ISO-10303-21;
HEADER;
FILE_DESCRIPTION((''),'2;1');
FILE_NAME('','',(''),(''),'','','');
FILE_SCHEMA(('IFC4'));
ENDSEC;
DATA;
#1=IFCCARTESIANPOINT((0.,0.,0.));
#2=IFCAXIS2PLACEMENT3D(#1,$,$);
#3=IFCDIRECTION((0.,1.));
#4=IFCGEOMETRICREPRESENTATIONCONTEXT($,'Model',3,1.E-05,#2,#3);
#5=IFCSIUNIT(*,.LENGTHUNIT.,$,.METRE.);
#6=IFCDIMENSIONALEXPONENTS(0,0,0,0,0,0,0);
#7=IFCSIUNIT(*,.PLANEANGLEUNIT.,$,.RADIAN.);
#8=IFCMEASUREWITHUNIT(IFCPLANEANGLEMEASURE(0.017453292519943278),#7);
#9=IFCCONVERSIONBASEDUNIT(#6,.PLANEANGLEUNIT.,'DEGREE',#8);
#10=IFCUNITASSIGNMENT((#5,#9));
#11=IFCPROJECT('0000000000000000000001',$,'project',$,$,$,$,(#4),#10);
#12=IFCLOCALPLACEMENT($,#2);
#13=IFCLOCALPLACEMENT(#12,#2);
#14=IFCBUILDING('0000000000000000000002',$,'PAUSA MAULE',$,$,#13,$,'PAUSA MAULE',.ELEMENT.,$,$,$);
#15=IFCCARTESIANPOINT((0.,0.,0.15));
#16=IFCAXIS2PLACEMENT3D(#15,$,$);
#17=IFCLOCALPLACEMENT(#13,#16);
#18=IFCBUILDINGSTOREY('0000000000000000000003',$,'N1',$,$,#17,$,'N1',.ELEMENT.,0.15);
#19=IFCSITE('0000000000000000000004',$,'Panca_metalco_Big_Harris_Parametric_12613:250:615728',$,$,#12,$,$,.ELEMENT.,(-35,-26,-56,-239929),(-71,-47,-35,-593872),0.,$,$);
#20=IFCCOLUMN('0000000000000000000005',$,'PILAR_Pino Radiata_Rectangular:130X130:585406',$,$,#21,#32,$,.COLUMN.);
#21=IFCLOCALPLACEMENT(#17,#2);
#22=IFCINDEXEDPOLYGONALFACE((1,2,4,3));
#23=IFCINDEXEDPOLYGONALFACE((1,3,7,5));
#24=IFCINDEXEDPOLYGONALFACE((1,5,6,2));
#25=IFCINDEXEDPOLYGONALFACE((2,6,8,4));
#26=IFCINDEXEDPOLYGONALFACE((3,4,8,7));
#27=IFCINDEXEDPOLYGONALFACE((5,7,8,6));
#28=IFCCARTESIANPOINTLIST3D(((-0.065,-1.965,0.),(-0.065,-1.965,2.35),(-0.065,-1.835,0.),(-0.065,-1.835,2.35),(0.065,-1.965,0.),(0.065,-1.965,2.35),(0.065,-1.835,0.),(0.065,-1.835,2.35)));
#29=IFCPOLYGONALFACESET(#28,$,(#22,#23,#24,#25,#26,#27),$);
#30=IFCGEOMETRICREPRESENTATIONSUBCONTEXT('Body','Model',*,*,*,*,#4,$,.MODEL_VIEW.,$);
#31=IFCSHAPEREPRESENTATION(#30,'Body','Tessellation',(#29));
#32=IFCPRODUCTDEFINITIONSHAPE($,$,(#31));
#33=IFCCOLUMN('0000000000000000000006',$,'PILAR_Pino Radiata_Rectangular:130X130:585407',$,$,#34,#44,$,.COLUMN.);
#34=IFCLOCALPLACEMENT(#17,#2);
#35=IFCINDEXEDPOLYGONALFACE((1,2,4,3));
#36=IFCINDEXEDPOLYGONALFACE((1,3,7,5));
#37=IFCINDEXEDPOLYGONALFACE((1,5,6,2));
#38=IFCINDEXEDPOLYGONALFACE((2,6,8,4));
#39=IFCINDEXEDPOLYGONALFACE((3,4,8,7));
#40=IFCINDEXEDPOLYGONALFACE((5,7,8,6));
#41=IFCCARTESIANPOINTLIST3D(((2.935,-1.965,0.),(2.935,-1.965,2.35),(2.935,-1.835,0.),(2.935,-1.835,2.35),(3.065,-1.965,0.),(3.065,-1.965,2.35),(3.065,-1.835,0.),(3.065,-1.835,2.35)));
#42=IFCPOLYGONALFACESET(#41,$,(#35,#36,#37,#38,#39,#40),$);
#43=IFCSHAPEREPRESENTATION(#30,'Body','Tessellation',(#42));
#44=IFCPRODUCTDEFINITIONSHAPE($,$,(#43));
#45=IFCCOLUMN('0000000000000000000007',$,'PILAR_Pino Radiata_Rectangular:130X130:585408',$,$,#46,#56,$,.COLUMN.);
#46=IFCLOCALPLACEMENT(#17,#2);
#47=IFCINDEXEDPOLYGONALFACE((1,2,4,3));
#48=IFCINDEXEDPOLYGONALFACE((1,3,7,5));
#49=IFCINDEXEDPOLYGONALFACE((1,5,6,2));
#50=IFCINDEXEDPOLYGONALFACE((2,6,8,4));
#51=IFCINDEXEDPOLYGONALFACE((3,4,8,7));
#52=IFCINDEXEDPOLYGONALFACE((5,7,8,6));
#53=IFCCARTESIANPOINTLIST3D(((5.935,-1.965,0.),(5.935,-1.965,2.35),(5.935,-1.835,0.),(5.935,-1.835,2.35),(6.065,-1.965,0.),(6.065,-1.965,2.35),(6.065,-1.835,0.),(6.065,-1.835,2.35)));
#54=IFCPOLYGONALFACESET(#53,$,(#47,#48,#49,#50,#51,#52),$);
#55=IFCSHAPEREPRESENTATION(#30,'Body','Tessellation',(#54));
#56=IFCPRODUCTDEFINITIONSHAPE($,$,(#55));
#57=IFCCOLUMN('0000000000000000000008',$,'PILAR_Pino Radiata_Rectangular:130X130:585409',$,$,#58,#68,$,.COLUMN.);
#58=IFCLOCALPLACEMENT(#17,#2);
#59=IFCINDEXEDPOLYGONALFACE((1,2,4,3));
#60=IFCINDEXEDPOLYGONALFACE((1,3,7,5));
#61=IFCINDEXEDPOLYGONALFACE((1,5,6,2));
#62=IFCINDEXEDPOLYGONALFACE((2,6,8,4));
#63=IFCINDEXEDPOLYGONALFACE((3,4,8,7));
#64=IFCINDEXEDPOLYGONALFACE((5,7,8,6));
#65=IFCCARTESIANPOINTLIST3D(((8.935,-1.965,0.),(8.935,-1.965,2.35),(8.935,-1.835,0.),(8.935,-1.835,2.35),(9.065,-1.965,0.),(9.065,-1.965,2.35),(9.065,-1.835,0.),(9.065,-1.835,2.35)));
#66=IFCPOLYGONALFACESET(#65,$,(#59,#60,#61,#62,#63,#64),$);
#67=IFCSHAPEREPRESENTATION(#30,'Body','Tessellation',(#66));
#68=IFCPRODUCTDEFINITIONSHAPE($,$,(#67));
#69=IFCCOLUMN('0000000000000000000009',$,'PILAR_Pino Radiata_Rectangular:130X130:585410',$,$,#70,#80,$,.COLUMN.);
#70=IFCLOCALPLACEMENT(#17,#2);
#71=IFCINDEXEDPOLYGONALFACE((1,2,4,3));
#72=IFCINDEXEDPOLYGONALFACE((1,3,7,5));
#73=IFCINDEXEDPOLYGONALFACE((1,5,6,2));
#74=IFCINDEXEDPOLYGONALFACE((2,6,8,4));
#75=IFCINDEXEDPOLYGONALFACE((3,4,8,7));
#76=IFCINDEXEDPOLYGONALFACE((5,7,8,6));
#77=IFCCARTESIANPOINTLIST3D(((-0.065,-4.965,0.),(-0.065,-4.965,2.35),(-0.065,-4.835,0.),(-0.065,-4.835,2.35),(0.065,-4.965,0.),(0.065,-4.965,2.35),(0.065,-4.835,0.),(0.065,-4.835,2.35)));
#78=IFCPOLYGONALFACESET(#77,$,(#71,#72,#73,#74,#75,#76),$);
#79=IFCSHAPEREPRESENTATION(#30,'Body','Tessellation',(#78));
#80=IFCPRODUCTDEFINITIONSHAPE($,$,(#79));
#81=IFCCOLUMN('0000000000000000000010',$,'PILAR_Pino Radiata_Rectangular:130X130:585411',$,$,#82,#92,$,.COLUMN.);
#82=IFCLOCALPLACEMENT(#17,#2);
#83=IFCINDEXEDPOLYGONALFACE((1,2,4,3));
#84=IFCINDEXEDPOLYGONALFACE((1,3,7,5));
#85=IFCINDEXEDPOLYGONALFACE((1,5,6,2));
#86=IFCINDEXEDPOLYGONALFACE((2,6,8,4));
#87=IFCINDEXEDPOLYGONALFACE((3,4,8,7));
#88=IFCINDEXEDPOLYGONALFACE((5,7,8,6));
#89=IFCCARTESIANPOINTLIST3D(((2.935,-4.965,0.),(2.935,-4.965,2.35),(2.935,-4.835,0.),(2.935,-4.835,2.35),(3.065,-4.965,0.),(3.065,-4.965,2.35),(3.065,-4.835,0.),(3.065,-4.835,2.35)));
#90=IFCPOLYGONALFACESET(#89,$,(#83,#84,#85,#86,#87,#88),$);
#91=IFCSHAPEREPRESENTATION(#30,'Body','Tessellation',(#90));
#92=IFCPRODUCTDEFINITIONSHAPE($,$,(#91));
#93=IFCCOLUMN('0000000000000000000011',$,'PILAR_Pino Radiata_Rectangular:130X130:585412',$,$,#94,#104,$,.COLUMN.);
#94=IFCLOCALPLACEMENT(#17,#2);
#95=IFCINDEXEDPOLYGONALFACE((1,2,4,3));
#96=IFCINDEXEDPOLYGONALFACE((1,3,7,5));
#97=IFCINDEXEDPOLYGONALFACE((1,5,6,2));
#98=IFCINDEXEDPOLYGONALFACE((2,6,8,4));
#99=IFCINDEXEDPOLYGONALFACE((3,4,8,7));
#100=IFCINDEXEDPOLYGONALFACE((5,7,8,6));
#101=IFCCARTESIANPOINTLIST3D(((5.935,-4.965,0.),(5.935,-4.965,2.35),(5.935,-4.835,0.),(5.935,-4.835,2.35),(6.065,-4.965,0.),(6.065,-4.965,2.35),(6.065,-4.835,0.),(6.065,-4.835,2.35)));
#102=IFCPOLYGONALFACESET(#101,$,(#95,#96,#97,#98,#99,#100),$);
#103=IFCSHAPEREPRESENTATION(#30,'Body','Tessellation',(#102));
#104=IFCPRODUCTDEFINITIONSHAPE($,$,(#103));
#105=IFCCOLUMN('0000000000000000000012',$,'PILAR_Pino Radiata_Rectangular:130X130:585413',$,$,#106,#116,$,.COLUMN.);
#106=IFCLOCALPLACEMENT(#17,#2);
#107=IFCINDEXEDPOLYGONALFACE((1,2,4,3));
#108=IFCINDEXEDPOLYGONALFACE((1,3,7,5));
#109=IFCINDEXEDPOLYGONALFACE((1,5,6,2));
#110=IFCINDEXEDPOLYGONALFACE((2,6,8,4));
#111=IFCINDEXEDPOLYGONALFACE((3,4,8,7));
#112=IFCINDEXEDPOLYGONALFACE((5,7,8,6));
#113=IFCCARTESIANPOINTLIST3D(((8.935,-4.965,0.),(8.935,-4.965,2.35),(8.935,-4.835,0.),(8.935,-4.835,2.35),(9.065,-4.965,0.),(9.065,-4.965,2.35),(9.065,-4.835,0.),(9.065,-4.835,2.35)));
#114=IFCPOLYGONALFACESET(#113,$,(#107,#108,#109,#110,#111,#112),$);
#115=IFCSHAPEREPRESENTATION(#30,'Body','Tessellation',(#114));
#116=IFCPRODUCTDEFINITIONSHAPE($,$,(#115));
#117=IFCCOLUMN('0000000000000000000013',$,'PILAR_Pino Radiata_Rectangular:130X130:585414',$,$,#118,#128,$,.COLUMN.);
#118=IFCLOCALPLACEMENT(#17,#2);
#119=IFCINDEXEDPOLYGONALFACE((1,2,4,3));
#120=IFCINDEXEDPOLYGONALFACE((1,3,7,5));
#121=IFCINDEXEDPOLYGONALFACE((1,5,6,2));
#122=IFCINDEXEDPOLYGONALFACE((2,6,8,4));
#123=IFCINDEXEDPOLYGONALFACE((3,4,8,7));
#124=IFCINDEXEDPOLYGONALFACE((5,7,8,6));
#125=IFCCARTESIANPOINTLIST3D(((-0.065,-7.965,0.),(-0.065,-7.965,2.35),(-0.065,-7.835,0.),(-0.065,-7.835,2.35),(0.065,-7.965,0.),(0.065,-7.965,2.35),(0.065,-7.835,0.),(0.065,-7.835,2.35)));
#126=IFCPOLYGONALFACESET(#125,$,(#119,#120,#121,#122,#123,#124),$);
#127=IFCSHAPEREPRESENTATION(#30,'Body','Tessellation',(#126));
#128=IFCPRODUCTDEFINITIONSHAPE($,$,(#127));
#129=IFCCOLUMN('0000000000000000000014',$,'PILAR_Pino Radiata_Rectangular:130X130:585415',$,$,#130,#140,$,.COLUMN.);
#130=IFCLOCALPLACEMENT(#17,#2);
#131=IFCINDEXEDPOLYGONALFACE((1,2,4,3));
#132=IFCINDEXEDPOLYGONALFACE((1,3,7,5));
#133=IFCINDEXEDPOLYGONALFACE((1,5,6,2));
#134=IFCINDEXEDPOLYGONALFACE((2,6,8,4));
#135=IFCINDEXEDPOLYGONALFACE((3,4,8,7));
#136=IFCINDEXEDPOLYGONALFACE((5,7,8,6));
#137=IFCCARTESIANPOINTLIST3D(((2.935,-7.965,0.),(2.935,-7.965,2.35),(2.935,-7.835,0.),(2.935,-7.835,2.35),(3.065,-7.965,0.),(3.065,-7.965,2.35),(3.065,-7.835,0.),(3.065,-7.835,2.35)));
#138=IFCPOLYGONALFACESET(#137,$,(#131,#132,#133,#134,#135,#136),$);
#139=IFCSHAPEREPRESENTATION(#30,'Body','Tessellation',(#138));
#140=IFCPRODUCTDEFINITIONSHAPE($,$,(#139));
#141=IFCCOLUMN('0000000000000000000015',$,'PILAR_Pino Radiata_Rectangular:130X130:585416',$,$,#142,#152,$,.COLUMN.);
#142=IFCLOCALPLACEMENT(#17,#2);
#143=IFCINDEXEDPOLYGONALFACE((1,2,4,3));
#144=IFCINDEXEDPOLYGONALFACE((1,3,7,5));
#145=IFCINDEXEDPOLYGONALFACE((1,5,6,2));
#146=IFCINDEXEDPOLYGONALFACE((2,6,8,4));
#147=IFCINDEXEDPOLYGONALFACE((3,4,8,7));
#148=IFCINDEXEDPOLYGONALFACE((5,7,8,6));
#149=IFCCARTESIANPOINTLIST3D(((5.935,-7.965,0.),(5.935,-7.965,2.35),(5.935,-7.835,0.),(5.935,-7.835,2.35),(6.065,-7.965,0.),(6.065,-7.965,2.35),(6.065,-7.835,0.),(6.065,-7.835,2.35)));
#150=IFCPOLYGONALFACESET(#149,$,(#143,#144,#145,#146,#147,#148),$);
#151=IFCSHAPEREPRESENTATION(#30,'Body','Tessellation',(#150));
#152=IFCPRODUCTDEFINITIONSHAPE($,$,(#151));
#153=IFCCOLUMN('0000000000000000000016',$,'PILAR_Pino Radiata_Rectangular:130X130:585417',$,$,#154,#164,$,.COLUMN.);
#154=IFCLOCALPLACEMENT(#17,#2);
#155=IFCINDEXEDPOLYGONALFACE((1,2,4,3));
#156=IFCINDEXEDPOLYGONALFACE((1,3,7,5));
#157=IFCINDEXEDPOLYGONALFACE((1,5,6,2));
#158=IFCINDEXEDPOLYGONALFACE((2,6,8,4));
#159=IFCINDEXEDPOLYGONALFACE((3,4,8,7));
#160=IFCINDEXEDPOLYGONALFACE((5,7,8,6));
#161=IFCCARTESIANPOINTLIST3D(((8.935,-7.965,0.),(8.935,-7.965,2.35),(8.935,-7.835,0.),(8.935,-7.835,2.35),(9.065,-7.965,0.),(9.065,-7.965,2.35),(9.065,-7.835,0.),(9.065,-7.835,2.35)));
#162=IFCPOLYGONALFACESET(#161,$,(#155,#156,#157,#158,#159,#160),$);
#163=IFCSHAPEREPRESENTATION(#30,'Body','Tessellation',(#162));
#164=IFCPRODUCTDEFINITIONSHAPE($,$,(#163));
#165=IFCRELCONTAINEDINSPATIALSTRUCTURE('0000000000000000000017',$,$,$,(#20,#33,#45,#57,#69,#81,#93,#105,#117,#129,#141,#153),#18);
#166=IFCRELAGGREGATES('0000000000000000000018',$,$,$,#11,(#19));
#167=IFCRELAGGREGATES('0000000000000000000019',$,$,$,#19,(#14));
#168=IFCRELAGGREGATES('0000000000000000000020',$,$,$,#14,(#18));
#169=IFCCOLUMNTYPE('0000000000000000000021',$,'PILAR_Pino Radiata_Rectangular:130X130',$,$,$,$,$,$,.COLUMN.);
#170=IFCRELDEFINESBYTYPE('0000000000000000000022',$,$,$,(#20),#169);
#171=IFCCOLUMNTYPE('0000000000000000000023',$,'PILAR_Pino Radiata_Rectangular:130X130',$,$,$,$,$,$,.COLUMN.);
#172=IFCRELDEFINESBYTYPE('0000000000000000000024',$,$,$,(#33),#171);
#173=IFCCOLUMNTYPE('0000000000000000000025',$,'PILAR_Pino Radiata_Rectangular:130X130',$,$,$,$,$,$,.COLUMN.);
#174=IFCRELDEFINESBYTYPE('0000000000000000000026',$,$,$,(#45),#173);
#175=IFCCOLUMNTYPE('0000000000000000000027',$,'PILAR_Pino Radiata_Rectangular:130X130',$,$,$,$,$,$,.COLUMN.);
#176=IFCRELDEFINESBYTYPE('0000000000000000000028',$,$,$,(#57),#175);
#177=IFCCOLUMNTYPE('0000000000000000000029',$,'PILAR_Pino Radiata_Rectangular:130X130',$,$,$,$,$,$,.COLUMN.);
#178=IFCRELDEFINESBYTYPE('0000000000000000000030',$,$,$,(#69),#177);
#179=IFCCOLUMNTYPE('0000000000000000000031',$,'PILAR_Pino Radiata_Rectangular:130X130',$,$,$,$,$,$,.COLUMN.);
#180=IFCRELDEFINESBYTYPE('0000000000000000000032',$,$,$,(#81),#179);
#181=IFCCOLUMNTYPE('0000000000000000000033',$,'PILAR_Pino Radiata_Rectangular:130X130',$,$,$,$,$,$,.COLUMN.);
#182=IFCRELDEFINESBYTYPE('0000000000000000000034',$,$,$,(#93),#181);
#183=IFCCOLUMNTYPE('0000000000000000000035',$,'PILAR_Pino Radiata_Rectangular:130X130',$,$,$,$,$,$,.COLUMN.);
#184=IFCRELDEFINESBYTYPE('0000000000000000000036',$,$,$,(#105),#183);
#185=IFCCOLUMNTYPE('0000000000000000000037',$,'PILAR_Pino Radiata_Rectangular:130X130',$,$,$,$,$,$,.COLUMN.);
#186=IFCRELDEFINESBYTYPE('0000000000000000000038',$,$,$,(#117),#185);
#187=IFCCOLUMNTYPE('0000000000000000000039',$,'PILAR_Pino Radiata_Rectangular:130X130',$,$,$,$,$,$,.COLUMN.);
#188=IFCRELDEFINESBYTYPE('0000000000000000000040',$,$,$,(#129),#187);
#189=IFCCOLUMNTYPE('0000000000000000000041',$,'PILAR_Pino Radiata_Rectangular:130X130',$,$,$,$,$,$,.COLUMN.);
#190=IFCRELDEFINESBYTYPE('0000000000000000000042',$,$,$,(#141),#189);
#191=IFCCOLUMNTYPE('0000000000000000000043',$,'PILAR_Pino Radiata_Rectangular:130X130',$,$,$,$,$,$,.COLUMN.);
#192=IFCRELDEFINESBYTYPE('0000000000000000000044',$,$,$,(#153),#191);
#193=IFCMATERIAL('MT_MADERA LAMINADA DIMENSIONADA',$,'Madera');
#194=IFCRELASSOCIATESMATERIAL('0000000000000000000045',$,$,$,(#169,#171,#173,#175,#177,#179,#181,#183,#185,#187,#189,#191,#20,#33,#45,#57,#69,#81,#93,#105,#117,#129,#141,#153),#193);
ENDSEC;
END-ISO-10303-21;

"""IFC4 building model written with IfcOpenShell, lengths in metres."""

from ifc_helpers import new_model, entity, si_unit, converted_unit, direction, frame, frame_2d, origin, origin_2d_with_axis, place, context, subcontext, project, spatial, rectangle, extrude, source, transform, mapped, material, material_profile, profile_set, profile_usage, type_object, type_shapes, element, save


model = new_model("IFC4")

# Units and contexts
model_context = context("Model", 3, precision=1e-05, world=origin(), true_north=direction((0.0, 1.0)))
body_context = subcontext(model_context, "Body", "Model", "MODEL_VIEW")
ifc_project = project(units=[si_unit("LENGTHUNIT", "METRE"), converted_unit("PLANEANGLEUNIT", "DEGREE", entity("IfcPlaneAngleMeasure", 0.017453292519943278), si_unit("PLANEANGLEUNIT", "RADIAN"), dimensions=[0, 0, 0, 0, 0, 0, 0])], contexts=[model_context])

# Site, building, storey
site_placement = place(None, origin())
site = spatial("IfcSite", under=ifc_project, at=site_placement, Name="Panca_metalco_Big_Harris_Parametric_12613:250:615728", CompositionType="ELEMENT", RefLatitude=(-35, -26, -56, -239929), RefLongitude=(-71, -47, -35, -593872), RefElevation=0.0)
building_placement = place(site_placement, origin())
building = spatial("IfcBuilding", under=site, at=building_placement, Name="PAUSA MAULE", LongName="PAUSA MAULE", CompositionType="ELEMENT")
storey_placement = place(building_placement, frame((0.0, 0.0, 0.15)))
storey = spatial("IfcBuildingStorey", under=building, at=storey_placement, Name="N1", LongName="N1", CompositionType="ELEMENT", Elevation=0.15)

# Columns
ifc_material_1 = material(Name="MT_MADERA LAMINADA DIMENSIONADA", Category="Madera")
ifc_material_profile = material_profile(ifc_material_1, rectangle(XDim=0.13, YDim=0.13, at=frame_2d((0.0, 0.0), x_axis=(1.0, 0.0))), Name="130X130")
ifc_profile_set = profile_set([ifc_material_profile], Name="130X130")
ifc_profile_usage = profile_usage(ifc_profile_set)
column_type_1 = type_object("IfcColumnType", Name="PILAR_Pino Radiata_Rectangular:130X130", PredefinedType="COLUMN", material=ifc_profile_set)
shared_shape_1 = source(origin(), body_context, "Body", "SweptSolid", [
    extrude(rectangle(XDim=0.13, YDim=0.13, at=frame_2d((0.0, 0.0), x_axis=(1.0, 0.0))), frame((0.0, -1.9, 0.15)), (0.0, 0.0, 1.0), 2.35),
])
type_shapes(column_type_1, [shared_shape_1])
column_1_placement = place(storey_placement, frame((0.0, 0.0, -0.15)))
element("IfcColumn", 1, at=column_1_placement, inside=storey, type_object=column_type_1, material=ifc_profile_usage, Name="PILAR_Pino Radiata_Rectangular:130X130:585406", PredefinedType="COLUMN", context=body_context, shape_type="MappedRepresentation", body=[
    mapped(shared_shape_1, transform((0.0, 0.0, 0.0), scale=1.0)),
])
column_type_2 = type_object("IfcColumnType", Name="PILAR_Pino Radiata_Rectangular:130X130", PredefinedType="COLUMN", material=ifc_profile_set)
shared_shape_2 = source(origin(), body_context, "Body", "SweptSolid", [
    extrude(rectangle(XDim=0.13, YDim=0.13, at=frame_2d((0.0, 0.0), x_axis=(1.0, 0.0))), frame((3.0, -1.9, 0.15)), (0.0, 0.0, 1.0), 2.35),
])
type_shapes(column_type_2, [shared_shape_2])
column_2_placement = place(storey_placement, frame((0.0, 0.0, -0.15)))
element("IfcColumn", 2, at=column_2_placement, inside=storey, type_object=column_type_2, material=ifc_profile_usage, Name="PILAR_Pino Radiata_Rectangular:130X130:585407", PredefinedType="COLUMN", context=body_context, shape_type="MappedRepresentation", body=[
    mapped(shared_shape_2, transform((0.0, 0.0, 0.0), scale=1.0)),
])
column_type_3 = type_object("IfcColumnType", Name="PILAR_Pino Radiata_Rectangular:130X130", PredefinedType="COLUMN", material=ifc_profile_set)
shared_shape_3 = source(origin(), body_context, "Body", "SweptSolid", [
    extrude(rectangle(XDim=0.13, YDim=0.13, at=frame_2d((0.0, 0.0), x_axis=(1.0, 0.0))), frame((6.0, -1.9, 0.15)), (0.0, 0.0, 1.0), 2.35),
])
type_shapes(column_type_3, [shared_shape_3])
column_3_placement = place(storey_placement, frame((0.0, 0.0, -0.15)))
element("IfcColumn", 3, at=column_3_placement, inside=storey, type_object=column_type_3, material=ifc_profile_usage, Name="PILAR_Pino Radiata_Rectangular:130X130:585408", PredefinedType="COLUMN", context=body_context, shape_type="MappedRepresentation", body=[
    mapped(shared_shape_3, transform((0.0, 0.0, 0.0), scale=1.0)),
])
column_type_4 = type_object("IfcColumnType", Name="PILAR_Pino Radiata_Rectangular:130X130", PredefinedType="COLUMN", material=ifc_profile_set)
shared_shape_4 = source(origin(), body_context, "Body", "SweptSolid", [
    extrude(rectangle(XDim=0.13, YDim=0.13, at=frame_2d((0.0, 0.0), x_axis=(1.0, 0.0))), frame((9.0, -1.9, 0.15)), (0.0, 0.0, 1.0), 2.35),
])
type_shapes(column_type_4, [shared_shape_4])
column_4_placement = place(storey_placement, frame((0.0, 0.0, -0.15)))
element("IfcColumn", 4, at=column_4_placement, inside=storey, type_object=column_type_4, material=ifc_profile_usage, Name="PILAR_Pino Radiata_Rectangular:130X130:585409", PredefinedType="COLUMN", context=body_context, shape_type="MappedRepresentation", body=[
    mapped(shared_shape_4, transform((0.0, 0.0, 0.0), scale=1.0)),
])
column_type_5 = type_object("IfcColumnType", Name="PILAR_Pino Radiata_Rectangular:130X130", PredefinedType="COLUMN", material=ifc_profile_set)
shared_shape_5 = source(origin(), body_context, "Body", "SweptSolid", [
    extrude(rectangle(XDim=0.13, YDim=0.13, at=frame_2d((0.0, 0.0), x_axis=(1.0, 0.0))), frame((0.0, -4.9, 0.15)), (0.0, 0.0, 1.0), 2.35),
])
type_shapes(column_type_5, [shared_shape_5])
column_5_placement = place(storey_placement, frame((0.0, 0.0, -0.15)))
element("IfcColumn", 5, at=column_5_placement, inside=storey, type_object=column_type_5, material=ifc_profile_usage, Name="PILAR_Pino Radiata_Rectangular:130X130:585410", PredefinedType="COLUMN", context=body_context, shape_type="MappedRepresentation", body=[
    mapped(shared_shape_5, transform((0.0, 0.0, 0.0), scale=1.0)),
])
column_type_6 = type_object("IfcColumnType", Name="PILAR_Pino Radiata_Rectangular:130X130", PredefinedType="COLUMN", material=ifc_profile_set)
shared_shape_6 = source(origin(), body_context, "Body", "SweptSolid", [
    extrude(rectangle(XDim=0.13, YDim=0.13, at=frame_2d((0.0, 0.0), x_axis=(1.0, 0.0))), frame((3.0, -4.9, 0.15)), (0.0, 0.0, 1.0), 2.35),
])
type_shapes(column_type_6, [shared_shape_6])
column_6_placement = place(storey_placement, frame((0.0, 0.0, -0.15)))
element("IfcColumn", 6, at=column_6_placement, inside=storey, type_object=column_type_6, material=ifc_profile_usage, Name="PILAR_Pino Radiata_Rectangular:130X130:585411", PredefinedType="COLUMN", context=body_context, shape_type="MappedRepresentation", body=[
    mapped(shared_shape_6, transform((0.0, 0.0, 0.0), scale=1.0)),
])
column_type_7 = type_object("IfcColumnType", Name="PILAR_Pino Radiata_Rectangular:130X130", PredefinedType="COLUMN", material=ifc_profile_set)
shared_shape_7 = source(origin(), body_context, "Body", "SweptSolid", [
    extrude(rectangle(XDim=0.13, YDim=0.13, at=frame_2d((0.0, 0.0), x_axis=(1.0, 0.0))), frame((6.0, -4.9, 0.15)), (0.0, 0.0, 1.0), 2.35),
])
type_shapes(column_type_7, [shared_shape_7])
column_7_placement = place(storey_placement, frame((0.0, 0.0, -0.15)))
element("IfcColumn", 7, at=column_7_placement, inside=storey, type_object=column_type_7, material=ifc_profile_usage, Name="PILAR_Pino Radiata_Rectangular:130X130:585412", PredefinedType="COLUMN", context=body_context, shape_type="MappedRepresentation", body=[
    mapped(shared_shape_7, transform((0.0, 0.0, 0.0), scale=1.0)),
])
column_type_8 = type_object("IfcColumnType", Name="PILAR_Pino Radiata_Rectangular:130X130", PredefinedType="COLUMN", material=ifc_profile_set)
shared_shape_8 = source(origin(), body_context, "Body", "SweptSolid", [
    extrude(rectangle(XDim=0.13, YDim=0.13, at=frame_2d((0.0, 0.0), x_axis=(1.0, 0.0))), frame((9.0, -4.9, 0.15)), (0.0, 0.0, 1.0), 2.35),
])
type_shapes(column_type_8, [shared_shape_8])
column_8_placement = place(storey_placement, frame((0.0, 0.0, -0.15)))
element("IfcColumn", 8, at=column_8_placement, inside=storey, type_object=column_type_8, material=ifc_profile_usage, Name="PILAR_Pino Radiata_Rectangular:130X130:585413", PredefinedType="COLUMN", context=body_context, shape_type="MappedRepresentation", body=[
    mapped(shared_shape_8, transform((0.0, 0.0, 0.0), scale=1.0)),
])
column_type_9 = type_object("IfcColumnType", Name="PILAR_Pino Radiata_Rectangular:130X130", PredefinedType="COLUMN", material=ifc_profile_set)
shared_shape_9 = source(origin(), body_context, "Body", "SweptSolid", [
    extrude(rectangle(XDim=0.13, YDim=0.13, at=frame_2d((0.0, 0.0), x_axis=(1.0, 0.0))), frame((0.0, -7.9, 0.15)), (0.0, 0.0, 1.0), 2.35),
])
type_shapes(column_type_9, [shared_shape_9])
column_9_placement = place(storey_placement, frame((0.0, 0.0, -0.15)))
element("IfcColumn", 9, at=column_9_placement, inside=storey, type_object=column_type_9, material=ifc_profile_usage, Name="PILAR_Pino Radiata_Rectangular:130X130:585414", PredefinedType="COLUMN", context=body_context, shape_type="MappedRepresentation", body=[
    mapped(shared_shape_9, transform((0.0, 0.0, 0.0), scale=1.0)),
])
column_type_10 = type_object("IfcColumnType", Name="PILAR_Pino Radiata_Rectangular:130X130", PredefinedType="COLUMN", material=ifc_profile_set)
shared_shape_10 = source(origin(), body_context, "Body", "SweptSolid", [
    extrude(rectangle(XDim=0.13, YDim=0.13, at=frame_2d((0.0, 0.0), x_axis=(1.0, 0.0))), frame((3.0, -7.9, 0.15)), (0.0, 0.0, 1.0), 2.35),
])
type_shapes(column_type_10, [shared_shape_10])
column_10_placement = place(storey_placement, frame((0.0, 0.0, -0.15)))
element("IfcColumn", 10, at=column_10_placement, inside=storey, type_object=column_type_10, material=ifc_profile_usage, Name="PILAR_Pino Radiata_Rectangular:130X130:585415", PredefinedType="COLUMN", context=body_context, shape_type="MappedRepresentation", body=[
    mapped(shared_shape_10, transform((0.0, 0.0, 0.0), scale=1.0)),
])
column_type_11 = type_object("IfcColumnType", Name="PILAR_Pino Radiata_Rectangular:130X130", PredefinedType="COLUMN", material=ifc_profile_set)
shared_shape_11 = source(origin(), body_context, "Body", "SweptSolid", [
    extrude(rectangle(XDim=0.13, YDim=0.13, at=origin_2d_with_axis()), frame((0.0, 0.0, 0.15), z_axis=(0.0, 0.0, 1.0), x_axis=(-1.0, 0.0, 0.0)), (0.0, 0.0, 1.0), 2.35),
])
type_shapes(column_type_11, [shared_shape_11])
column_11_placement = place(storey_placement, frame((6.0, -7.9, -0.15), z_axis=(0.0, 0.0, 1.0), x_axis=(-1.0, 0.0, 0.0)))
element("IfcColumn", 11, at=column_11_placement, inside=storey, type_object=column_type_11, material=ifc_profile_usage, Name="PILAR_Pino Radiata_Rectangular:130X130:585416", PredefinedType="COLUMN", context=body_context, shape_type="MappedRepresentation", body=[
    mapped(shared_shape_11, transform((0.0, 0.0, 0.0), scale=1.0)),
])
column_type_12 = type_object("IfcColumnType", Name="PILAR_Pino Radiata_Rectangular:130X130", PredefinedType="COLUMN", material=ifc_profile_set)
shared_shape_12 = source(origin(), body_context, "Body", "SweptSolid", [
    extrude(rectangle(XDim=0.13, YDim=0.13, at=frame_2d((0.0, 0.0), x_axis=(1.0, 0.0))), frame((9.0, -7.9, 0.15)), (0.0, 0.0, 1.0), 2.35),
])
type_shapes(column_type_12, [shared_shape_12])
column_12_placement = place(storey_placement, frame((0.0, 0.0, -0.15)))
element("IfcColumn", 12, at=column_12_placement, inside=storey, type_object=column_type_12, material=ifc_profile_usage, Name="PILAR_Pino Radiata_Rectangular:130X130:585417", PredefinedType="COLUMN", context=body_context, shape_type="MappedRepresentation", body=[
    mapped(shared_shape_12, transform((0.0, 0.0, 0.0), scale=1.0)),
])

save(model, "model.ifc")
